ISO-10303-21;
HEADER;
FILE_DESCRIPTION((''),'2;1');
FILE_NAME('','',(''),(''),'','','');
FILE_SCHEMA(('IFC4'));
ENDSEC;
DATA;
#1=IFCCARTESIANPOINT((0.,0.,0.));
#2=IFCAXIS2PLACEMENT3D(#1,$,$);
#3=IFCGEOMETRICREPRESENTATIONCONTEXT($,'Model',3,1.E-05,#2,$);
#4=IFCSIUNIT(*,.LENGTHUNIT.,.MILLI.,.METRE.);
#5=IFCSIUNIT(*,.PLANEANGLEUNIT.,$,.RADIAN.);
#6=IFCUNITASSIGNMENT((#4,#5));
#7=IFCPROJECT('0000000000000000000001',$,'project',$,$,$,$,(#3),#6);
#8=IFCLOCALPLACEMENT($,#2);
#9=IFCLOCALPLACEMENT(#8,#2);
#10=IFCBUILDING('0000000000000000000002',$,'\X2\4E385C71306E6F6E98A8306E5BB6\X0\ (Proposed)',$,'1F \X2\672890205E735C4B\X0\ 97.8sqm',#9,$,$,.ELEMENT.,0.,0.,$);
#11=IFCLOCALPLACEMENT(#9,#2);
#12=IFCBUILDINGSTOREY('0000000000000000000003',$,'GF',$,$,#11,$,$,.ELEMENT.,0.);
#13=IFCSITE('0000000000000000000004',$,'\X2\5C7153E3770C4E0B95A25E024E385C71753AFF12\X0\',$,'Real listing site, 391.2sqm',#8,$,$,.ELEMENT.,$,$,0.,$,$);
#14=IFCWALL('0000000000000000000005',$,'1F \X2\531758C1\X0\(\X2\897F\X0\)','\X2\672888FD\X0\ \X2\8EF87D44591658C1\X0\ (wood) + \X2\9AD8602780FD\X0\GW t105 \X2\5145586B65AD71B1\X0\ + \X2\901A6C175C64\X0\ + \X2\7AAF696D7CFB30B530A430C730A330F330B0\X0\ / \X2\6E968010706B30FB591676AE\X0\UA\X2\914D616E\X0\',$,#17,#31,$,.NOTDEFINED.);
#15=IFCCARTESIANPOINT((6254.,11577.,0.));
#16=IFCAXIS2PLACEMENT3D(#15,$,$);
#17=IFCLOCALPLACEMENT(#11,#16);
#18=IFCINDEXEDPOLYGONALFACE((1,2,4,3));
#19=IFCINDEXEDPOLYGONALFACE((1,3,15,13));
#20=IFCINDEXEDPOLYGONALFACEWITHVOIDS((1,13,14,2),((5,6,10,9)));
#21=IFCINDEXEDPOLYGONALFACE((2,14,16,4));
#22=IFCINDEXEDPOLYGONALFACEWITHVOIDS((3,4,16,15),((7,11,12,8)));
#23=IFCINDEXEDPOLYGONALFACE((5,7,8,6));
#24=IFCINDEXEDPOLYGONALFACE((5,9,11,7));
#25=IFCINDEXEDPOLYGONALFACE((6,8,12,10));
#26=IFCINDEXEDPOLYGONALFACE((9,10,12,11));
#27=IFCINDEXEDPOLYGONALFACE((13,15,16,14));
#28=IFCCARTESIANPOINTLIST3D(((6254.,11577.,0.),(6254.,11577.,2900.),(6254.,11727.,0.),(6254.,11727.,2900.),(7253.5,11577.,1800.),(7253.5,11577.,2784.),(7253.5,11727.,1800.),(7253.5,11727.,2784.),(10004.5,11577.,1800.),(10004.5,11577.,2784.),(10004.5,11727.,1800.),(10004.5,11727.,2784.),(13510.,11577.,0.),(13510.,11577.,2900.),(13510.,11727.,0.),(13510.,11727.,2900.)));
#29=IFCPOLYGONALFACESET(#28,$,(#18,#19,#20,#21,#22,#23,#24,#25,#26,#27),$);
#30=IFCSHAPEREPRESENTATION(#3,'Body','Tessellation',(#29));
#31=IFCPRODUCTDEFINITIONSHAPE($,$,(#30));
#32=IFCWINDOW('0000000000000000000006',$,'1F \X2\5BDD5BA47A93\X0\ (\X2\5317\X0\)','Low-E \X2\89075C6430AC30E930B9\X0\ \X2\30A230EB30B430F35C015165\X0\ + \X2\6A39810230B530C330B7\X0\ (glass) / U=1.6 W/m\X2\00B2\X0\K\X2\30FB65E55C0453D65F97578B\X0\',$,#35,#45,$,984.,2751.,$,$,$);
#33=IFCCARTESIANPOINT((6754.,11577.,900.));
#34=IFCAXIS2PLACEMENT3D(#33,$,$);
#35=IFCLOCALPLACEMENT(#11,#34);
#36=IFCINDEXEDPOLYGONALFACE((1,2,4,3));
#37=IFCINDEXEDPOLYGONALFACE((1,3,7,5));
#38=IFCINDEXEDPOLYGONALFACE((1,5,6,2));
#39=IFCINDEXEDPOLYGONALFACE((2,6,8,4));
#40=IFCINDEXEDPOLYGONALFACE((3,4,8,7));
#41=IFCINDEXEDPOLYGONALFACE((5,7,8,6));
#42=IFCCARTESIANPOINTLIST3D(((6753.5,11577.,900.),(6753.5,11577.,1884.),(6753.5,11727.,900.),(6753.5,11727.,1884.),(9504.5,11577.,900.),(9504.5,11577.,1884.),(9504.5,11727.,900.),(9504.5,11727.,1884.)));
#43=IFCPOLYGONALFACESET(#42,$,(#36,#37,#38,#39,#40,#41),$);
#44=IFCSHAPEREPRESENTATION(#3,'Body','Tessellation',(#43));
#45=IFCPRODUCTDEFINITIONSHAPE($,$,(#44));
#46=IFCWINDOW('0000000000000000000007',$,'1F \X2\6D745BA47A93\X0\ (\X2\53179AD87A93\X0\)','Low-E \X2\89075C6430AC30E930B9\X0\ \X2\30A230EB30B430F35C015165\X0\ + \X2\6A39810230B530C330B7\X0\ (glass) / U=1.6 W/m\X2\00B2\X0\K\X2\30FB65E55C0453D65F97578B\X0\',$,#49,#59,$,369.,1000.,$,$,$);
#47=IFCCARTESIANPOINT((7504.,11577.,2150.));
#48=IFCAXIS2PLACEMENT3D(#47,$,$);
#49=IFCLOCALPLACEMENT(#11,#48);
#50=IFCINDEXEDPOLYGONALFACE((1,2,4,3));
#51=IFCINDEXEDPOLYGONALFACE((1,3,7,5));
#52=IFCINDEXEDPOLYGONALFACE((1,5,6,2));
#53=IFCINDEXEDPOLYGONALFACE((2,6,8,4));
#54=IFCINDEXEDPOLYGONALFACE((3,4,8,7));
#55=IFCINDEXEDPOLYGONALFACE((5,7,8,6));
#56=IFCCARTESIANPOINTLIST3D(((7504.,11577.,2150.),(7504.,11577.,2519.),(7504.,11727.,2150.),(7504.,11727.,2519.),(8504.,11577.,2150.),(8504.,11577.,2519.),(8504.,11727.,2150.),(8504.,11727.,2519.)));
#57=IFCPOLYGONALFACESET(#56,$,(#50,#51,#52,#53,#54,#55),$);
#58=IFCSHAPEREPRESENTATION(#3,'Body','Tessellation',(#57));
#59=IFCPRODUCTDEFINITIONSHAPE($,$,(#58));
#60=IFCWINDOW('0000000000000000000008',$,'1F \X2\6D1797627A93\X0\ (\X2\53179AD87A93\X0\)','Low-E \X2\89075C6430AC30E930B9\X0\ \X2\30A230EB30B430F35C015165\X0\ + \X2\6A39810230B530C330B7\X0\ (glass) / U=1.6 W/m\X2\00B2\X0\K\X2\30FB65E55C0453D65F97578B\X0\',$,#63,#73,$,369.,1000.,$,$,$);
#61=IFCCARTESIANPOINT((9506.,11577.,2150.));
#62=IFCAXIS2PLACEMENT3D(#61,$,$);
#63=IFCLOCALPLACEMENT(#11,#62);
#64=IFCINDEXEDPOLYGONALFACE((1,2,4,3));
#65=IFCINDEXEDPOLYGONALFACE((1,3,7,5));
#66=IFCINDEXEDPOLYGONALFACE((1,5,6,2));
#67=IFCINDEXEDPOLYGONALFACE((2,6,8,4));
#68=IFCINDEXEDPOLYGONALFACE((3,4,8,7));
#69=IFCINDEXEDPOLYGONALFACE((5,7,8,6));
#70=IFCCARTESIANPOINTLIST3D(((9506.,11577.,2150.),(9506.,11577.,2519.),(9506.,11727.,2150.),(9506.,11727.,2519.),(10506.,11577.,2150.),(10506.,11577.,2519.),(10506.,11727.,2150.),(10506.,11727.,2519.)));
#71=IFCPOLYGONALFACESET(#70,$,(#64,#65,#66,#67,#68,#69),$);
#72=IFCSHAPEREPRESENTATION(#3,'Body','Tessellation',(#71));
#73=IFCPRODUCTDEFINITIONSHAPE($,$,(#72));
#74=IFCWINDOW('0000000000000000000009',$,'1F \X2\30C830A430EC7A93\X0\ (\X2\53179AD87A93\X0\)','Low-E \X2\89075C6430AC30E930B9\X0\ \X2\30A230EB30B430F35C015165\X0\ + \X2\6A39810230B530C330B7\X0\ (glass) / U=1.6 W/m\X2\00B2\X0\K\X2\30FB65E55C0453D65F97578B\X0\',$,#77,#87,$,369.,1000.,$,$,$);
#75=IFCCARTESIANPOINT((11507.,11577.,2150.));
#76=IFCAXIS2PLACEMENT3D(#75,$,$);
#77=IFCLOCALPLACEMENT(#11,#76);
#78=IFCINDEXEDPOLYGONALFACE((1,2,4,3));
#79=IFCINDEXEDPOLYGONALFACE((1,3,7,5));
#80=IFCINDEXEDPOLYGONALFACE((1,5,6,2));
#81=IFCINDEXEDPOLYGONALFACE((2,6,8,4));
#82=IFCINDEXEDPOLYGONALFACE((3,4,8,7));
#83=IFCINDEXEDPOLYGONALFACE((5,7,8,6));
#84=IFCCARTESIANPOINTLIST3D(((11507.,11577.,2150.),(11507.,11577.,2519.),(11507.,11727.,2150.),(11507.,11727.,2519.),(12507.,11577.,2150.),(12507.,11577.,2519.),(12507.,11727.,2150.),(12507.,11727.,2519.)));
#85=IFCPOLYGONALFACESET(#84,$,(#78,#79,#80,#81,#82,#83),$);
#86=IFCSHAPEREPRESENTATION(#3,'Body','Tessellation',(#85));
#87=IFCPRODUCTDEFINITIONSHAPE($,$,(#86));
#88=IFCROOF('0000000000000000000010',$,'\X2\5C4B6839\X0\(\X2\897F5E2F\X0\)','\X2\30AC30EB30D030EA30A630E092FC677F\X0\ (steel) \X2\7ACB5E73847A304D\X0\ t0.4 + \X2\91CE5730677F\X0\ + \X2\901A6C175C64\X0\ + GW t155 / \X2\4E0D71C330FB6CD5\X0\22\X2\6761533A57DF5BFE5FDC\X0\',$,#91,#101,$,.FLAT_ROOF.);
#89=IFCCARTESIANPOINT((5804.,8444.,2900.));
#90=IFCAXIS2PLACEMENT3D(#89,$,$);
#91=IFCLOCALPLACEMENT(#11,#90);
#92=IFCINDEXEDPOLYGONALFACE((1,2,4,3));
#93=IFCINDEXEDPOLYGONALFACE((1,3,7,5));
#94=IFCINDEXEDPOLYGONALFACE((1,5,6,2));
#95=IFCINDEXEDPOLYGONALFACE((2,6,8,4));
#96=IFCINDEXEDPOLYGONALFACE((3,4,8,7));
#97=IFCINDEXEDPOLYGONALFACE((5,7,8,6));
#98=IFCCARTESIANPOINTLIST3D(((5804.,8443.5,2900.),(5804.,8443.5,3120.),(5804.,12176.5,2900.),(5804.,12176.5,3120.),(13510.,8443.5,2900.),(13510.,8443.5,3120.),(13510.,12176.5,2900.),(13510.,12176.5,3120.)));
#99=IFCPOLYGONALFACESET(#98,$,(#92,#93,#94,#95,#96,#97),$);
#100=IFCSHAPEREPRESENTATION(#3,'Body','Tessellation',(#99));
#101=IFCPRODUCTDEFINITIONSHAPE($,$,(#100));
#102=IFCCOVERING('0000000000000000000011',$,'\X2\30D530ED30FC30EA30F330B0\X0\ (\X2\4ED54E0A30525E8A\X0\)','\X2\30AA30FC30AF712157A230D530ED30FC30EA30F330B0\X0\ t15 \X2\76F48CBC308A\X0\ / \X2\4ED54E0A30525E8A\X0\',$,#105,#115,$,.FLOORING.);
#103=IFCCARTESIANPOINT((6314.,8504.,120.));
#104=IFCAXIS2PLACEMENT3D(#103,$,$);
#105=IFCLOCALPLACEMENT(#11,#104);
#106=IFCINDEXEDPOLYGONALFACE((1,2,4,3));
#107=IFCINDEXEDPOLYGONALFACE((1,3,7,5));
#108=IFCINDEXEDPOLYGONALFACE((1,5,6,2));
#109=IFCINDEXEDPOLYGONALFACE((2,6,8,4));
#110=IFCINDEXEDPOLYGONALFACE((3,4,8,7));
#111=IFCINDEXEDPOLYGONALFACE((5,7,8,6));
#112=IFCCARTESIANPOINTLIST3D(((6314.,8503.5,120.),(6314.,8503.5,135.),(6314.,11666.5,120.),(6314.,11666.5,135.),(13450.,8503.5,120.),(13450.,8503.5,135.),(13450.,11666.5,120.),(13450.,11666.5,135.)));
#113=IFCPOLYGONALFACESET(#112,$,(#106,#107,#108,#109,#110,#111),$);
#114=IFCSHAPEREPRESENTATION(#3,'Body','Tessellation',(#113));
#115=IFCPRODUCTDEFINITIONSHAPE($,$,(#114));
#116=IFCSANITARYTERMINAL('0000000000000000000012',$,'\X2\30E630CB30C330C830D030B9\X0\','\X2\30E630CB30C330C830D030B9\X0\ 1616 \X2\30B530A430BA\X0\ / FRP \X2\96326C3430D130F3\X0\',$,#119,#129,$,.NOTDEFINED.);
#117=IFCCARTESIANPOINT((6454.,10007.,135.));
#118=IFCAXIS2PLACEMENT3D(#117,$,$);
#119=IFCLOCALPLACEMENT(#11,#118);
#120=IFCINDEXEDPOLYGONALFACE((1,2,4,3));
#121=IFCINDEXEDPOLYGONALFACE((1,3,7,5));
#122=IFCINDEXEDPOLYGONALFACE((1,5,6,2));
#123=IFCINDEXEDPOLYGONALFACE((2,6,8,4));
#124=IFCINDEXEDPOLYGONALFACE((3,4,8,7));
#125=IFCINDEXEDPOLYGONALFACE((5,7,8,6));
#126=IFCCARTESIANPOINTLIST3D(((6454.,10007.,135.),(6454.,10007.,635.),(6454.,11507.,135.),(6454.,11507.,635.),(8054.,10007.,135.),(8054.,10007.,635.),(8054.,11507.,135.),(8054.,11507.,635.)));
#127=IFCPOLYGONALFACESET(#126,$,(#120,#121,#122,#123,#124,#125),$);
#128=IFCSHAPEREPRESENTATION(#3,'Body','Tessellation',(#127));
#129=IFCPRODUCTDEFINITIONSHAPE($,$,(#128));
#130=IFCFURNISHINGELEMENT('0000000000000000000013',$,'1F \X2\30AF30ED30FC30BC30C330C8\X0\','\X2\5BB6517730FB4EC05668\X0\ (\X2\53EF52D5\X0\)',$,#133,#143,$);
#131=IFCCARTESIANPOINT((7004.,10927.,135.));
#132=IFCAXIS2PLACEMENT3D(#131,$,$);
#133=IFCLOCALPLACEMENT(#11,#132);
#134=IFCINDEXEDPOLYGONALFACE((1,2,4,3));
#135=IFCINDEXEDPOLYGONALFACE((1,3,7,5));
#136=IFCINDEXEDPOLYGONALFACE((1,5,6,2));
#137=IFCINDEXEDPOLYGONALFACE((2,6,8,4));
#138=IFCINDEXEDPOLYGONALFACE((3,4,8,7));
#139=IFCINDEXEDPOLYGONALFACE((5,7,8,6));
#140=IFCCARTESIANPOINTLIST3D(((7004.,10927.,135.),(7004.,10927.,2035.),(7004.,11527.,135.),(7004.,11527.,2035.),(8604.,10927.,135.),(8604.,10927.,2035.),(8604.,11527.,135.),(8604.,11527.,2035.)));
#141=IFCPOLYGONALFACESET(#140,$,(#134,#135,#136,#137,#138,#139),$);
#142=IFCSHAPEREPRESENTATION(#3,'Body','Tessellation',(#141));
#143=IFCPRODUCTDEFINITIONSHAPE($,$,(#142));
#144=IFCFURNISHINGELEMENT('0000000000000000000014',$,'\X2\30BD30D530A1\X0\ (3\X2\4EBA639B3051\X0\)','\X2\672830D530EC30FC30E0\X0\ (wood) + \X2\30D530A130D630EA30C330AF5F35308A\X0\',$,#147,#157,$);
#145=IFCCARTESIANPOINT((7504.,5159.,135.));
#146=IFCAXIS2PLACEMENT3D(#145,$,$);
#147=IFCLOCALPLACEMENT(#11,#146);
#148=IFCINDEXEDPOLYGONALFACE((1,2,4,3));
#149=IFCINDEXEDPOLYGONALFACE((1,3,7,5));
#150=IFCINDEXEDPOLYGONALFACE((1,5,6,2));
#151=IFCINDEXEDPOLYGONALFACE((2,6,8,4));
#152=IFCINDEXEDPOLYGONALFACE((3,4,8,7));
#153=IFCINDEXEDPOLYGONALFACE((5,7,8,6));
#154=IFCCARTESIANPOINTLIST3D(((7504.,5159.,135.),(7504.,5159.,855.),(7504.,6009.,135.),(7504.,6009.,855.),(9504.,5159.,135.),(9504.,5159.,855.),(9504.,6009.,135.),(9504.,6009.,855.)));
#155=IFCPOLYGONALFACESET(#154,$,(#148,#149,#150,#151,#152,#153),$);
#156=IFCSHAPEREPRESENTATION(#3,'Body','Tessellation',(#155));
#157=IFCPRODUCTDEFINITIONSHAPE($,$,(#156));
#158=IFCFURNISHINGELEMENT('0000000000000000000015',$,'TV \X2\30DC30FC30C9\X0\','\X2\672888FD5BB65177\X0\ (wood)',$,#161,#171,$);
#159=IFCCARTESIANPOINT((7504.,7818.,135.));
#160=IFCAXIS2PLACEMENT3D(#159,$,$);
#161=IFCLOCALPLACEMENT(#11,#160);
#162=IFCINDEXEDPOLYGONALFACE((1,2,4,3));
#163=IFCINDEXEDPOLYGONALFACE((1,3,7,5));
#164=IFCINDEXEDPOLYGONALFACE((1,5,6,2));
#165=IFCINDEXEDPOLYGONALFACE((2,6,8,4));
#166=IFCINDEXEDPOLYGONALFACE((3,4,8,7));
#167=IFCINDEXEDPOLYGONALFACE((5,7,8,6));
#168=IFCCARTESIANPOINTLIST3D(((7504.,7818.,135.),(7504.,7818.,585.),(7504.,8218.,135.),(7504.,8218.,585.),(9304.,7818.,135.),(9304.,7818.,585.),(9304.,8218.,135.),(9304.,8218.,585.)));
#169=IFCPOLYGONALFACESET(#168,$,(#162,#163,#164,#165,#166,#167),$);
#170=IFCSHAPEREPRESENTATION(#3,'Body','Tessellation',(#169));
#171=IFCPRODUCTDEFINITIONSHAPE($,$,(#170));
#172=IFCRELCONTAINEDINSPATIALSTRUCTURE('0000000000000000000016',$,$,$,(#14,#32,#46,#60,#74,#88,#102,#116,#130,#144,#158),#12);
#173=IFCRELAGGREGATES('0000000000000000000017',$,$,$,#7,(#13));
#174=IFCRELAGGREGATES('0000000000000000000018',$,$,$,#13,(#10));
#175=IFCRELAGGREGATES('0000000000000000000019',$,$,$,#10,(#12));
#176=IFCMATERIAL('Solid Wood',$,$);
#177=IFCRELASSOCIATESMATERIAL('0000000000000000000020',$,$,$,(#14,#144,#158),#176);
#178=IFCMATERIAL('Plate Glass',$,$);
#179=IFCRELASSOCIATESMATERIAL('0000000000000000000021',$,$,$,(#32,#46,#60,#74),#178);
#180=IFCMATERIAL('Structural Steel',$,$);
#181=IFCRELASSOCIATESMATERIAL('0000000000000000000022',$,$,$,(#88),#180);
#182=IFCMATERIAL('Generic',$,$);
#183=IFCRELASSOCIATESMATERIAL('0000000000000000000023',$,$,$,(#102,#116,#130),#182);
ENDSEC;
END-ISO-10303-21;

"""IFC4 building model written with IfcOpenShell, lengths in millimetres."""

from ifc_helpers import new_model, si_unit, frame, frame_2d, origin, place, context, project, spatial, rectangle, extrude, material, element, fill, save


model = new_model("IFC4")

# Units and contexts
model_context = context("Model", 3, precision=1e-05, world=origin())
ifc_project = project(units=[si_unit("LENGTHUNIT", "METRE", prefix="MILLI"), si_unit("PLANEANGLEUNIT", "RADIAN")], contexts=[model_context])

# Site, building, storey
site_placement = place(None, origin())
site = spatial("IfcSite", under=ifc_project, at=site_placement, Name="山口県下関市丸山町２", ObjectType="Real listing site, 391.2sqm", CompositionType="ELEMENT", RefElevation=0.0)
building_placement = place(site_placement, origin())
building = spatial("IfcBuilding", under=site, at=building_placement, Name="丸山の潮風の家 (Proposed)", ObjectType="1F 木造平屋 97.8sqm", CompositionType="ELEMENT", ElevationOfRefHeight=0.0, ElevationOfTerrain=0.0)
storey_placement = place(building_placement, origin())
storey = spatial("IfcBuildingStorey", under=building, at=storey_placement, Name="GF", CompositionType="ELEMENT", Elevation=0.0)

# Shared definitions
ifc_material_1 = material(Name="Solid Wood")

# Shared definitions
ifc_material_2 = material(Name="Plate Glass")

# Wall, openings, windows
wall_1_placement = place(storey_placement, frame((6254.0, 11577.0, 0.0)))
wall_1 = element("IfcWall", 1, at=wall_1_placement, inside=storey, material=ifc_material_1, Name="1F 北壁(西)", Description="木製 軸組外壁 (wood) + 高性能GW t105 充填断熱 + 通気層 + 窯業系サイディング / 準耐火・外皮UA配慮", PredefinedType="NOTDEFINED", context=model_context, shape_type="SweptSolid", body=[
    extrude(rectangle(XDim=7256.0, YDim=150.0, at=frame_2d((3628.0, 75.0))), frame((6254.0, 11577.0, 0.0)), (0.0, 0.0, 1.0), 2900.0),
])
opening_1_placement = place(storey_placement, frame((6754.0, 11577.0, 900.0)))
opening_1 = element("IfcOpeningElement", 2, at=opening_1_placement, cuts=wall_1, PredefinedType="NOTDEFINED", context=model_context, shape_type="SweptSolid", body=[
    extrude(rectangle(XDim=2751.0, YDim=150.0, at=frame_2d((1375.0, 75.0))), frame((6754.0, 11577.0, 900.0)), (0.0, 0.0, 1.0), 984.0),
])
opening_2_placement = place(storey_placement, frame((7504.0, 11577.0, 2150.0)))
opening_2 = element("IfcOpeningElement", 3, at=opening_2_placement, cuts=wall_1, PredefinedType="NOTDEFINED", context=model_context, shape_type="SweptSolid", body=[
    extrude(rectangle(XDim=1000.0, YDim=150.0, at=frame_2d((500.0, 75.0))), frame((7504.0, 11577.0, 2150.0)), (0.0, 0.0, 1.0), 369.0),
])
opening_3_placement = place(storey_placement, frame((9506.0, 11577.0, 2150.0)))
opening_3 = element("IfcOpeningElement", 4, at=opening_3_placement, cuts=wall_1, PredefinedType="NOTDEFINED", context=model_context, shape_type="SweptSolid", body=[
    extrude(rectangle(XDim=1000.0, YDim=150.0, at=frame_2d((500.0, 75.0))), frame((9506.0, 11577.0, 2150.0)), (0.0, 0.0, 1.0), 369.0),
])
opening_4_placement = place(storey_placement, frame((11507.0, 11577.0, 2150.0)))
opening_4 = element("IfcOpeningElement", 5, at=opening_4_placement, cuts=wall_1, PredefinedType="NOTDEFINED", context=model_context, shape_type="SweptSolid", body=[
    extrude(rectangle(XDim=1000.0, YDim=150.0, at=frame_2d((500.0, 75.0))), frame((11507.0, 11577.0, 2150.0)), (0.0, 0.0, 1.0), 369.0),
])
window_1_placement = place(storey_placement, frame((6754.0, 11577.0, 900.0)))
window_1 = element("IfcWindow", 6, at=window_1_placement, inside=storey, material=ifc_material_2, Name="1F 寝室窓 (北)", Description="Low-E 複層ガラス アルゴン封入 + 樹脂サッシ (glass) / U=1.6 W/m²K・日射取得型", OverallHeight=984.0, OverallWidth=2751.0, context=model_context, shape_type="SweptSolid", body=[
    extrude(rectangle(XDim=2751.0, YDim=150.0, at=frame_2d((1375.0, 75.0))), frame((6754.0, 11577.0, 900.0)), (0.0, 0.0, 1.0), 984.0),
])
fill(opening_1, window_1)
window_2_placement = place(storey_placement, frame((7504.0, 11577.0, 2150.0)))
window_2 = element("IfcWindow", 7, at=window_2_placement, inside=storey, material=ifc_material_2, Name="1F 浴室窓 (北高窓)", Description="Low-E 複層ガラス アルゴン封入 + 樹脂サッシ (glass) / U=1.6 W/m²K・日射取得型", OverallHeight=369.0, OverallWidth=1000.0, context=model_context, shape_type="SweptSolid", body=[
    extrude(rectangle(XDim=1000.0, YDim=150.0, at=frame_2d((500.0, 75.0))), frame((7504.0, 11577.0, 2150.0)), (0.0, 0.0, 1.0), 369.0),
])
fill(opening_2, window_2)
window_3_placement = place(storey_placement, frame((9506.0, 11577.0, 2150.0)))
window_3 = element("IfcWindow", 8, at=window_3_placement, inside=storey, material=ifc_material_2, Name="1F 洗面窓 (北高窓)", Description="Low-E 複層ガラス アルゴン封入 + 樹脂サッシ (glass) / U=1.6 W/m²K・日射取得型", OverallHeight=369.0, OverallWidth=1000.0, context=model_context, shape_type="SweptSolid", body=[
    extrude(rectangle(XDim=1000.0, YDim=150.0, at=frame_2d((500.0, 75.0))), frame((9506.0, 11577.0, 2150.0)), (0.0, 0.0, 1.0), 369.0),
])
fill(opening_3, window_3)
window_4_placement = place(storey_placement, frame((11507.0, 11577.0, 2150.0)))
window_4 = element("IfcWindow", 9, at=window_4_placement, inside=storey, material=ifc_material_2, Name="1F トイレ窓 (北高窓)", Description="Low-E 複層ガラス アルゴン封入 + 樹脂サッシ (glass) / U=1.6 W/m²K・日射取得型", OverallHeight=369.0, OverallWidth=1000.0, context=model_context, shape_type="SweptSolid", body=[
    extrude(rectangle(XDim=1000.0, YDim=150.0, at=frame_2d((500.0, 75.0))), frame((11507.0, 11577.0, 2150.0)), (0.0, 0.0, 1.0), 369.0),
])
fill(opening_4, window_4)

# Roof
ifc_material_3 = material(Name="Structural Steel")
roof_1_placement = place(storey_placement, frame((5804.0, 8444.0, 2900.0)))
element("IfcRoof", 10, at=roof_1_placement, inside=storey, material=ifc_material_3, Name="屋根(西帯)", Description="ガルバリウム鋼板 (steel) 立平葺き t0.4 + 野地板 + 通気層 + GW t155 / 不燃・法22条区域対応", PredefinedType="FLAT_ROOF", context=model_context, shape_type="SweptSolid", body=[
    extrude(rectangle(XDim=7706.0, YDim=3733.0, at=frame_2d((3853.0, 1866.0))), frame((5804.0, 8444.0, 2900.0)), (0.0, 0.0, 1.0), 220.0),
])

# Covering
ifc_material_4 = material(Name="Generic")
covering_1_placement = place(storey_placement, frame((6314.0, 8504.0, 120.0)))
element("IfcCovering", 11, at=covering_1_placement, inside=storey, material=ifc_material_4, Name="フローリング (仕上げ床)", Description="オーク無垢フローリング t15 直貼り / 仕上げ床", PredefinedType="FLOORING", context=model_context, shape_type="SweptSolid", body=[
    extrude(rectangle(XDim=7136.0, YDim=3163.0, at=frame_2d((3568.0, 1581.0))), frame((6314.0, 8504.0, 120.0)), (0.0, 0.0, 1.0), 15.0),
])

# Sanitary terminal
sanitary_terminal_placement = place(storey_placement, frame((6454.0, 10007.0, 135.0)))
element("IfcSanitaryTerminal", 12, at=sanitary_terminal_placement, inside=storey, material=ifc_material_4, Name="ユニットバス", Description="ユニットバス 1616 サイズ / FRP 防水パン", PredefinedType="NOTDEFINED", context=model_context, shape_type="SweptSolid", body=[
    extrude(rectangle(XDim=1600.0, YDim=1500.0, at=frame_2d((800.0, 750.0))), frame((6454.0, 10007.0, 135.0)), (0.0, 0.0, 1.0), 500.0),
])

# Furnishing elements
furnishing_1_placement = place(storey_placement, frame((7004.0, 10927.0, 135.0)))
element("IfcFurnishingElement", 13, at=furnishing_1_placement, inside=storey, material=ifc_material_4, Name="1F クローゼット", Description="家具・什器 (可動)", context=model_context, shape_type="SweptSolid", body=[
    extrude(rectangle(XDim=1600.0, YDim=600.0, at=frame_2d((800.0, 300.0))), frame((7004.0, 10927.0, 135.0)), (0.0, 0.0, 1.0), 1900.0),
])
furnishing_2_placement = place(storey_placement, frame((7504.0, 5159.0, 135.0)))
element("IfcFurnishingElement", 14, at=furnishing_2_placement, inside=storey, material=ifc_material_1, Name="ソファ (3人掛け)", Description="木フレーム (wood) + ファブリック張り", context=model_context, shape_type="SweptSolid", body=[
    extrude(rectangle(XDim=2000.0, YDim=850.0, at=frame_2d((1000.0, 425.0))), frame((7504.0, 5159.0, 135.0)), (0.0, 0.0, 1.0), 720.0),
])
furnishing_3_placement = place(storey_placement, frame((7504.0, 7818.0, 135.0)))
element("IfcFurnishingElement", 15, at=furnishing_3_placement, inside=storey, material=ifc_material_1, Name="TV ボード", Description="木製家具 (wood)", context=model_context, shape_type="SweptSolid", body=[
    extrude(rectangle(XDim=1800.0, YDim=400.0, at=frame_2d((900.0, 200.0))), frame((7504.0, 7818.0, 135.0)), (0.0, 0.0, 1.0), 450.0),
])

save(model, "model.ifc")
